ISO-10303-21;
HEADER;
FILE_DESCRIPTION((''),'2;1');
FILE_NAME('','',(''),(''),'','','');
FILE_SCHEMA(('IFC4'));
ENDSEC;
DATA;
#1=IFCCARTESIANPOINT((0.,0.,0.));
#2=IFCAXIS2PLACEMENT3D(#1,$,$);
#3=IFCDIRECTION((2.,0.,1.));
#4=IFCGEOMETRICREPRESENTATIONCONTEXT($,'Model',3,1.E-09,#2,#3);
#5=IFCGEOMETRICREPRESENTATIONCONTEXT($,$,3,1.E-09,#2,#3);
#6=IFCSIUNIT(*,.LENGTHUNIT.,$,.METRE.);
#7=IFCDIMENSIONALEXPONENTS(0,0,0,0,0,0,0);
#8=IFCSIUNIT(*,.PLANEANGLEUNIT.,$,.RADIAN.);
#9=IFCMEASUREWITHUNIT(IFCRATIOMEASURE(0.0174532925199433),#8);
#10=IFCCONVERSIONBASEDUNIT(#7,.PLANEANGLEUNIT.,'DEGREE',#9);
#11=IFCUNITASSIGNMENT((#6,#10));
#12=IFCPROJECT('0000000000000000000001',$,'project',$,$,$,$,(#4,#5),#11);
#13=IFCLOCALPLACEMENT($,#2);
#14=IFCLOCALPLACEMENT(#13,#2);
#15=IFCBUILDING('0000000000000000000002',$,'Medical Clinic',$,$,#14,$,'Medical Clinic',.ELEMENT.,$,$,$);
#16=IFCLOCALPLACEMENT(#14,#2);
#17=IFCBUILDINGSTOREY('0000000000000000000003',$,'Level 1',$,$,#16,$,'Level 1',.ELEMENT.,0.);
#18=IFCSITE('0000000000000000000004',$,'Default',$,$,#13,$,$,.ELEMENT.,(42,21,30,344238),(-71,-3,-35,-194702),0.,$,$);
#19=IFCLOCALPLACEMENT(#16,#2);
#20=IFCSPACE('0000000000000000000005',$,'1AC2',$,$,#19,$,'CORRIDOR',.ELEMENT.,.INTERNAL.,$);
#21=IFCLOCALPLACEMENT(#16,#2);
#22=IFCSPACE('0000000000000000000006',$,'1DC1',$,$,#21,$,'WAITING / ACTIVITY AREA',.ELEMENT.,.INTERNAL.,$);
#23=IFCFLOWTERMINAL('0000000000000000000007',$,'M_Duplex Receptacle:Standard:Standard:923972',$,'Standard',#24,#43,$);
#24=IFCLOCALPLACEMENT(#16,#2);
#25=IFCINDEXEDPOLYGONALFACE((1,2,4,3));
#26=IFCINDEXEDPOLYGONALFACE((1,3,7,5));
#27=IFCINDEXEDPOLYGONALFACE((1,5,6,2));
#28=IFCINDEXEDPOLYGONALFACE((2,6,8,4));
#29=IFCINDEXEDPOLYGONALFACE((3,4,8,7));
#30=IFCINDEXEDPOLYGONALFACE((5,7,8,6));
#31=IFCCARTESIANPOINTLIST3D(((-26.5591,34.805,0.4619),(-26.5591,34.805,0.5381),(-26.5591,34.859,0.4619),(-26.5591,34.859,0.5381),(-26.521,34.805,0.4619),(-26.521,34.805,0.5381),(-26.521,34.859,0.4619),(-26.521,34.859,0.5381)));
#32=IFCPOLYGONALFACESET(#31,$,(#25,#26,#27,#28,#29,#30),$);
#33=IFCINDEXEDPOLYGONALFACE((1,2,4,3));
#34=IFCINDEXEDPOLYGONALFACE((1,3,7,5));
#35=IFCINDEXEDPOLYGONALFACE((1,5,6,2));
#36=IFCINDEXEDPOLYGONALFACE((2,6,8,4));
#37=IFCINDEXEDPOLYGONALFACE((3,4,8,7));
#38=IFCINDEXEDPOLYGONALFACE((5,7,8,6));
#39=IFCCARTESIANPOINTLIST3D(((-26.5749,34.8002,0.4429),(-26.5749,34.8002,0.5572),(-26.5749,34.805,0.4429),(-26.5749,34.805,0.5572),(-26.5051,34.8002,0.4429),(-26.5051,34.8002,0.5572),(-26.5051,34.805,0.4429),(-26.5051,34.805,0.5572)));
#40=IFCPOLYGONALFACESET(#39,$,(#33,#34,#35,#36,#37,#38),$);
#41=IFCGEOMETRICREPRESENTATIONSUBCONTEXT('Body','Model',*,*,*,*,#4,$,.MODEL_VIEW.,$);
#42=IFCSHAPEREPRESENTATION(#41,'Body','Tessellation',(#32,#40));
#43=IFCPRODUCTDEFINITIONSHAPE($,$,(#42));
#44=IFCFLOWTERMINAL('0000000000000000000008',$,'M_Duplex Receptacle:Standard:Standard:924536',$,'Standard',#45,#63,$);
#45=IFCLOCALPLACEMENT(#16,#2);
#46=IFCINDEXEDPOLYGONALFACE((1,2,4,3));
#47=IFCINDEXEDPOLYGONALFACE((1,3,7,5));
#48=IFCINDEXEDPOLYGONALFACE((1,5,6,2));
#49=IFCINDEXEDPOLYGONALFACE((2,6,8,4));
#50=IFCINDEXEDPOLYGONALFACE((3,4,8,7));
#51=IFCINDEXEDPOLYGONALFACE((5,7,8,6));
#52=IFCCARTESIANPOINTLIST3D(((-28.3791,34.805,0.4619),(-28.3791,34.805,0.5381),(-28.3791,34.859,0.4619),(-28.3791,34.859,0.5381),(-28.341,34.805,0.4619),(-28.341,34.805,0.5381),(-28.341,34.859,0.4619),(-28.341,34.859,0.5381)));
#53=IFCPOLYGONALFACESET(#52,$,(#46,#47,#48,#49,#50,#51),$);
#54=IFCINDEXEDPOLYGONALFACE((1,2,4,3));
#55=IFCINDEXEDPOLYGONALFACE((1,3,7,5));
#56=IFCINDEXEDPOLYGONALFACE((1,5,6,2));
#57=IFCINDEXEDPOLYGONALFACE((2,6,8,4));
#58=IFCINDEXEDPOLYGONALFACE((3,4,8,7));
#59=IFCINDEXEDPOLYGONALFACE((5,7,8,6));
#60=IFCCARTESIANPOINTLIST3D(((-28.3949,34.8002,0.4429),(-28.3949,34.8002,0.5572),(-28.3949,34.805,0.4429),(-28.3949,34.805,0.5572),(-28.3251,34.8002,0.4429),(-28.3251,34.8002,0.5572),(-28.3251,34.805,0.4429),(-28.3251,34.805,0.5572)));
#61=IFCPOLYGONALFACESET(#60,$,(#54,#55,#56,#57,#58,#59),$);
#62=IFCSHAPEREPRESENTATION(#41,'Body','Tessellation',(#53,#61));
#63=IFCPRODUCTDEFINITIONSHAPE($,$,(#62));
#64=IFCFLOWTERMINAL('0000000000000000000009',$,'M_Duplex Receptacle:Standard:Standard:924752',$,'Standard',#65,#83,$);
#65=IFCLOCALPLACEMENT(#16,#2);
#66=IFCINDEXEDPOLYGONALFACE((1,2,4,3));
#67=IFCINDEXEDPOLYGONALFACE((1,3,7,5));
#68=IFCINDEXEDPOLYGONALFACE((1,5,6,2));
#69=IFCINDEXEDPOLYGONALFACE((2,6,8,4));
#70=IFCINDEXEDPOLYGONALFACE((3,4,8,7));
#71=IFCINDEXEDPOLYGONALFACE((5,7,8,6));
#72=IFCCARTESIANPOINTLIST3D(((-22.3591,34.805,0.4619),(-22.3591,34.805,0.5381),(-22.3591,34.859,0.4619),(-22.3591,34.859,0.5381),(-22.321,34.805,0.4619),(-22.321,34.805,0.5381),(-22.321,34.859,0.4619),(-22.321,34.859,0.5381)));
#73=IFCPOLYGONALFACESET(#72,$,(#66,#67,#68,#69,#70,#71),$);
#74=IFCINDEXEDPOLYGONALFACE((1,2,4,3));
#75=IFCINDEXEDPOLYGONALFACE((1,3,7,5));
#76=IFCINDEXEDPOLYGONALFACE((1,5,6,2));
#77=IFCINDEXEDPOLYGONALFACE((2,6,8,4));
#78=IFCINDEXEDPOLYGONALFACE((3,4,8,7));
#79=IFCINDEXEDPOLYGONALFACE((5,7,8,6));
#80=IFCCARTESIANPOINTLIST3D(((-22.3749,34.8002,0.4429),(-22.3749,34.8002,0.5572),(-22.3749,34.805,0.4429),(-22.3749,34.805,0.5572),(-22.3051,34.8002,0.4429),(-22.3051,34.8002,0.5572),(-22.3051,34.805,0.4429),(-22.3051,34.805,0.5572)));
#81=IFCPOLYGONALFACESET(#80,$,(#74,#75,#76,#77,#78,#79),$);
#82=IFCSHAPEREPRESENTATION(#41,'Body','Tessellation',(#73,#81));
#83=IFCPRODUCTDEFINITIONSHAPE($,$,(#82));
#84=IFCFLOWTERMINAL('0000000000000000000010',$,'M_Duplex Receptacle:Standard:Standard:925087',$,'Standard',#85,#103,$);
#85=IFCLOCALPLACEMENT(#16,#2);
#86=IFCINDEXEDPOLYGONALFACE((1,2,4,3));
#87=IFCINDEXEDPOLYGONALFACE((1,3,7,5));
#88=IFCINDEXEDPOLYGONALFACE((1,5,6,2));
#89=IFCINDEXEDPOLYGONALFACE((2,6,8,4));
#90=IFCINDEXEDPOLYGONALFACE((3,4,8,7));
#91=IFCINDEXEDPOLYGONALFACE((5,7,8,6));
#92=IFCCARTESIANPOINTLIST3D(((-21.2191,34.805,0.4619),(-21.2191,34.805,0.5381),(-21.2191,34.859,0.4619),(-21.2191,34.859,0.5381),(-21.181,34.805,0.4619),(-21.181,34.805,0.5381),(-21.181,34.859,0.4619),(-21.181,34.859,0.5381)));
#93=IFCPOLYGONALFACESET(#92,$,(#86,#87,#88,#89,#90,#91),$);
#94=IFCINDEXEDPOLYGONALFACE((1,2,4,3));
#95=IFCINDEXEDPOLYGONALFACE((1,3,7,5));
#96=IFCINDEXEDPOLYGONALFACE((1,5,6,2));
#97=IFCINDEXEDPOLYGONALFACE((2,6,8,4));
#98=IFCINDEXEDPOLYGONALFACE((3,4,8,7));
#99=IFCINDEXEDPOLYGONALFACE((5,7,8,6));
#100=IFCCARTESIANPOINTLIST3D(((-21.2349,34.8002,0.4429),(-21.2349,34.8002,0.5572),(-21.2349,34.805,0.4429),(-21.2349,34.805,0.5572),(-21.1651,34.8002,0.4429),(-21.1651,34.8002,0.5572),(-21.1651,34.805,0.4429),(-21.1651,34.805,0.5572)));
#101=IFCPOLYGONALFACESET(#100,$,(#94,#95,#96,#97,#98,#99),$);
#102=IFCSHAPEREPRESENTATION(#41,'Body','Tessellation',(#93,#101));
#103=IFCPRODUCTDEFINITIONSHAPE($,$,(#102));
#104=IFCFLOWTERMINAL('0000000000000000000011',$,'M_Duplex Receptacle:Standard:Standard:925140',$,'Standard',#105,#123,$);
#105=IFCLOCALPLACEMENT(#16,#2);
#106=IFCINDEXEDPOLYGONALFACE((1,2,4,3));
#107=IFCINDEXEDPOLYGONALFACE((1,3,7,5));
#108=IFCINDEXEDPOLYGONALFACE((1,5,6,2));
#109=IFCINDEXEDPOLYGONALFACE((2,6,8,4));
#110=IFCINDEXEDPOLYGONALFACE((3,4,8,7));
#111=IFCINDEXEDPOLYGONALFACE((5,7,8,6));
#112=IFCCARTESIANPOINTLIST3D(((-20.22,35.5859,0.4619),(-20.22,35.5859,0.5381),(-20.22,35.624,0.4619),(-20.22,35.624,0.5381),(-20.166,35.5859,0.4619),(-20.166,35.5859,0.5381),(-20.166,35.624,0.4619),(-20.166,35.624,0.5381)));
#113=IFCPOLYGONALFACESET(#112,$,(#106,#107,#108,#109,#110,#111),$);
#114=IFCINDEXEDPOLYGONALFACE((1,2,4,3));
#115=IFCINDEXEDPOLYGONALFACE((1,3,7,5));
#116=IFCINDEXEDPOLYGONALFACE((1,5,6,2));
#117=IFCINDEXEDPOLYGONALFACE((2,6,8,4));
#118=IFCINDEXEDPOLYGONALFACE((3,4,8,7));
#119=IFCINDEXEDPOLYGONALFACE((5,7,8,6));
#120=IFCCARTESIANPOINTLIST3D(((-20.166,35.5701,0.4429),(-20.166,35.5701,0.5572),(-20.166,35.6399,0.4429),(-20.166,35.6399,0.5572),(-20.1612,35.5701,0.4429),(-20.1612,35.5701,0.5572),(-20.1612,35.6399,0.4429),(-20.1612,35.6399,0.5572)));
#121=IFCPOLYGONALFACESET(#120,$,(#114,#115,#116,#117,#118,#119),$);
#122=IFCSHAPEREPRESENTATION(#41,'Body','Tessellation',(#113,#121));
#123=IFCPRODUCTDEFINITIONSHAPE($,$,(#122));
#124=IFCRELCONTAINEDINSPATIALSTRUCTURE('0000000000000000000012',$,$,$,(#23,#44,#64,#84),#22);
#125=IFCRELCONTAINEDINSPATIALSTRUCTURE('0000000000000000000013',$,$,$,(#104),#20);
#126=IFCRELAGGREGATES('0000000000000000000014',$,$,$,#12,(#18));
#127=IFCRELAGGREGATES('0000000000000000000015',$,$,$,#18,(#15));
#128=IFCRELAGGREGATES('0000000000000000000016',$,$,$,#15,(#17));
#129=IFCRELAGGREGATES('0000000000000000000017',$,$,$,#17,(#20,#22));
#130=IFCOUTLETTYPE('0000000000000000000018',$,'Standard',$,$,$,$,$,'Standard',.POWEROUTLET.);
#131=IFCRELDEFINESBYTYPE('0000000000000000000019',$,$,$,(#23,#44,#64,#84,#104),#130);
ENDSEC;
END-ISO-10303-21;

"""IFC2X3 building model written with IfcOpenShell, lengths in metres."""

from ifc_helpers import new_model, entity, si_unit, converted_unit, direction, frame, frame_2d, origin, origin_2d_with_axis, place, context, subcontext, project, spatial, rectangle, extrude, source, transform, mapped, type_object, type_shapes, element, save


model = new_model("IFC2X3")

# Units and contexts
model_context = context("Model", 3, precision=1e-09, world=origin(), true_north=direction((2.0, 0.0, 1.0)))
context_of_model = context(None, 3, precision=1e-09, world=origin(), true_north=direction((2.0, 0.0, 1.0)))
body_context = subcontext(model_context, "Body", "Model", "MODEL_VIEW")
ifc_project = project(units=[si_unit("LENGTHUNIT", "METRE"), converted_unit("PLANEANGLEUNIT", "DEGREE", entity("IfcRatioMeasure", 0.0174532925199433), si_unit("PLANEANGLEUNIT", "RADIAN"), dimensions=[0, 0, 0, 0, 0, 0, 0])], contexts=[model_context, context_of_model])

# Site, building, storey
site_placement = place(None, origin())
site = spatial("IfcSite", under=ifc_project, at=site_placement, Name="Default", CompositionType="ELEMENT", RefLatitude=(42, 21, 30, 344238), RefLongitude=(-71, -3, -35, -194702), RefElevation=0.0)
building_placement = place(site_placement, origin())
building = spatial("IfcBuilding", under=site, at=building_placement, Name="Medical Clinic", LongName="Medical Clinic", CompositionType="ELEMENT")
storey_placement = place(building_placement, origin())
storey = spatial("IfcBuildingStorey", under=building, at=storey_placement, Name="Level 1", LongName="Level 1", CompositionType="ELEMENT", Elevation=0.0)

# Shared definitions
space_1_placement = place(storey_placement, origin())
space_1 = spatial("IfcSpace", under=storey, at=space_1_placement, Name="1AC2", LongName="CORRIDOR", CompositionType="ELEMENT", InteriorOrExteriorSpace="INTERNAL")

# Shared definitions
space_2_placement = place(storey_placement, origin())
space_2 = spatial("IfcSpace", under=storey, at=space_2_placement, Name="1DC1", LongName="WAITING / ACTIVITY AREA", CompositionType="ELEMENT", InteriorOrExteriorSpace="INTERNAL")

# Shared definitions
outlet_type = type_object("IfcOutletType", Name="Standard", ElementType="Standard", PredefinedType="POWEROUTLET")
shared_shape_1 = source(origin(), body_context, "Body", "SweptSolid", [
    extrude(rectangle(XDim=0.0381, YDim=0.0762, at=origin_2d_with_axis()), frame((0.0, 0.0, -0.054), z_axis=(0.0, 0.0, 1.0), x_axis=(-1.0, 0.0, 0.0)), (0.0, 0.0, 1.0), 0.054),
    extrude(rectangle(XDim=0.0698, YDim=0.1143, at=frame_2d((0.0, 0.0), x_axis=(1.0, 0.0))), frame((0.0, 0.0, 0.0), z_axis=(0.0, 0.0, 1.0), x_axis=(-1.0, 0.0, 0.0)), (0.0, 0.0, 1.0), 0.0048),
])
type_shapes(outlet_type, [shared_shape_1])

# Flow terminals
for number, where, z_axis, x_axis, name in (
    (1, (-26.54, 34.805, 0.5), (0.0, -1.0, 0.0), (1.0, 0.0, 0.0), "M_Duplex Receptacle:Standard:Standard:923972"),
    (2, (-28.36, 34.805, 0.5), (0.0, -1.0, 0.0), (1.0, 0.0, 0.0), "M_Duplex Receptacle:Standard:Standard:924536"),
    (3, (-22.34, 34.805, 0.5), (0.0, -1.0, 0.0), (1.0, 0.0, 0.0), "M_Duplex Receptacle:Standard:Standard:924752"),
    (4, (-21.2, 34.805, 0.5), (0.0, -1.0, 0.0), (1.0, 0.0, 0.0), "M_Duplex Receptacle:Standard:Standard:925087"),
):
    element("IfcFlowTerminal", number, at=place(space_2_placement, frame(where, z_axis=z_axis, x_axis=x_axis)), inside=space_2, type_object=outlet_type, Name=name, ObjectType="Standard", context=body_context, shape_type="MappedRepresentation", body=[
        mapped(shared_shape_1, transform((0.0, 0.0, 0.0), scale=1.0)),
    ])
flow_terminal_1_placement = place(space_1_placement, frame((-20.166, 35.605, 0.5), z_axis=(1.0, 0.0, 0.0), x_axis=(0.0, 1.0, 0.0)))
element("IfcFlowTerminal", 5, at=flow_terminal_1_placement, inside=space_1, type_object=outlet_type, Name="M_Duplex Receptacle:Standard:Standard:925140", ObjectType="Standard", context=body_context, shape_type="MappedRepresentation", body=[
    mapped(shared_shape_1, transform((0.0, 0.0, 0.0), scale=1.0)),
])

save(model, "model.ifc")
